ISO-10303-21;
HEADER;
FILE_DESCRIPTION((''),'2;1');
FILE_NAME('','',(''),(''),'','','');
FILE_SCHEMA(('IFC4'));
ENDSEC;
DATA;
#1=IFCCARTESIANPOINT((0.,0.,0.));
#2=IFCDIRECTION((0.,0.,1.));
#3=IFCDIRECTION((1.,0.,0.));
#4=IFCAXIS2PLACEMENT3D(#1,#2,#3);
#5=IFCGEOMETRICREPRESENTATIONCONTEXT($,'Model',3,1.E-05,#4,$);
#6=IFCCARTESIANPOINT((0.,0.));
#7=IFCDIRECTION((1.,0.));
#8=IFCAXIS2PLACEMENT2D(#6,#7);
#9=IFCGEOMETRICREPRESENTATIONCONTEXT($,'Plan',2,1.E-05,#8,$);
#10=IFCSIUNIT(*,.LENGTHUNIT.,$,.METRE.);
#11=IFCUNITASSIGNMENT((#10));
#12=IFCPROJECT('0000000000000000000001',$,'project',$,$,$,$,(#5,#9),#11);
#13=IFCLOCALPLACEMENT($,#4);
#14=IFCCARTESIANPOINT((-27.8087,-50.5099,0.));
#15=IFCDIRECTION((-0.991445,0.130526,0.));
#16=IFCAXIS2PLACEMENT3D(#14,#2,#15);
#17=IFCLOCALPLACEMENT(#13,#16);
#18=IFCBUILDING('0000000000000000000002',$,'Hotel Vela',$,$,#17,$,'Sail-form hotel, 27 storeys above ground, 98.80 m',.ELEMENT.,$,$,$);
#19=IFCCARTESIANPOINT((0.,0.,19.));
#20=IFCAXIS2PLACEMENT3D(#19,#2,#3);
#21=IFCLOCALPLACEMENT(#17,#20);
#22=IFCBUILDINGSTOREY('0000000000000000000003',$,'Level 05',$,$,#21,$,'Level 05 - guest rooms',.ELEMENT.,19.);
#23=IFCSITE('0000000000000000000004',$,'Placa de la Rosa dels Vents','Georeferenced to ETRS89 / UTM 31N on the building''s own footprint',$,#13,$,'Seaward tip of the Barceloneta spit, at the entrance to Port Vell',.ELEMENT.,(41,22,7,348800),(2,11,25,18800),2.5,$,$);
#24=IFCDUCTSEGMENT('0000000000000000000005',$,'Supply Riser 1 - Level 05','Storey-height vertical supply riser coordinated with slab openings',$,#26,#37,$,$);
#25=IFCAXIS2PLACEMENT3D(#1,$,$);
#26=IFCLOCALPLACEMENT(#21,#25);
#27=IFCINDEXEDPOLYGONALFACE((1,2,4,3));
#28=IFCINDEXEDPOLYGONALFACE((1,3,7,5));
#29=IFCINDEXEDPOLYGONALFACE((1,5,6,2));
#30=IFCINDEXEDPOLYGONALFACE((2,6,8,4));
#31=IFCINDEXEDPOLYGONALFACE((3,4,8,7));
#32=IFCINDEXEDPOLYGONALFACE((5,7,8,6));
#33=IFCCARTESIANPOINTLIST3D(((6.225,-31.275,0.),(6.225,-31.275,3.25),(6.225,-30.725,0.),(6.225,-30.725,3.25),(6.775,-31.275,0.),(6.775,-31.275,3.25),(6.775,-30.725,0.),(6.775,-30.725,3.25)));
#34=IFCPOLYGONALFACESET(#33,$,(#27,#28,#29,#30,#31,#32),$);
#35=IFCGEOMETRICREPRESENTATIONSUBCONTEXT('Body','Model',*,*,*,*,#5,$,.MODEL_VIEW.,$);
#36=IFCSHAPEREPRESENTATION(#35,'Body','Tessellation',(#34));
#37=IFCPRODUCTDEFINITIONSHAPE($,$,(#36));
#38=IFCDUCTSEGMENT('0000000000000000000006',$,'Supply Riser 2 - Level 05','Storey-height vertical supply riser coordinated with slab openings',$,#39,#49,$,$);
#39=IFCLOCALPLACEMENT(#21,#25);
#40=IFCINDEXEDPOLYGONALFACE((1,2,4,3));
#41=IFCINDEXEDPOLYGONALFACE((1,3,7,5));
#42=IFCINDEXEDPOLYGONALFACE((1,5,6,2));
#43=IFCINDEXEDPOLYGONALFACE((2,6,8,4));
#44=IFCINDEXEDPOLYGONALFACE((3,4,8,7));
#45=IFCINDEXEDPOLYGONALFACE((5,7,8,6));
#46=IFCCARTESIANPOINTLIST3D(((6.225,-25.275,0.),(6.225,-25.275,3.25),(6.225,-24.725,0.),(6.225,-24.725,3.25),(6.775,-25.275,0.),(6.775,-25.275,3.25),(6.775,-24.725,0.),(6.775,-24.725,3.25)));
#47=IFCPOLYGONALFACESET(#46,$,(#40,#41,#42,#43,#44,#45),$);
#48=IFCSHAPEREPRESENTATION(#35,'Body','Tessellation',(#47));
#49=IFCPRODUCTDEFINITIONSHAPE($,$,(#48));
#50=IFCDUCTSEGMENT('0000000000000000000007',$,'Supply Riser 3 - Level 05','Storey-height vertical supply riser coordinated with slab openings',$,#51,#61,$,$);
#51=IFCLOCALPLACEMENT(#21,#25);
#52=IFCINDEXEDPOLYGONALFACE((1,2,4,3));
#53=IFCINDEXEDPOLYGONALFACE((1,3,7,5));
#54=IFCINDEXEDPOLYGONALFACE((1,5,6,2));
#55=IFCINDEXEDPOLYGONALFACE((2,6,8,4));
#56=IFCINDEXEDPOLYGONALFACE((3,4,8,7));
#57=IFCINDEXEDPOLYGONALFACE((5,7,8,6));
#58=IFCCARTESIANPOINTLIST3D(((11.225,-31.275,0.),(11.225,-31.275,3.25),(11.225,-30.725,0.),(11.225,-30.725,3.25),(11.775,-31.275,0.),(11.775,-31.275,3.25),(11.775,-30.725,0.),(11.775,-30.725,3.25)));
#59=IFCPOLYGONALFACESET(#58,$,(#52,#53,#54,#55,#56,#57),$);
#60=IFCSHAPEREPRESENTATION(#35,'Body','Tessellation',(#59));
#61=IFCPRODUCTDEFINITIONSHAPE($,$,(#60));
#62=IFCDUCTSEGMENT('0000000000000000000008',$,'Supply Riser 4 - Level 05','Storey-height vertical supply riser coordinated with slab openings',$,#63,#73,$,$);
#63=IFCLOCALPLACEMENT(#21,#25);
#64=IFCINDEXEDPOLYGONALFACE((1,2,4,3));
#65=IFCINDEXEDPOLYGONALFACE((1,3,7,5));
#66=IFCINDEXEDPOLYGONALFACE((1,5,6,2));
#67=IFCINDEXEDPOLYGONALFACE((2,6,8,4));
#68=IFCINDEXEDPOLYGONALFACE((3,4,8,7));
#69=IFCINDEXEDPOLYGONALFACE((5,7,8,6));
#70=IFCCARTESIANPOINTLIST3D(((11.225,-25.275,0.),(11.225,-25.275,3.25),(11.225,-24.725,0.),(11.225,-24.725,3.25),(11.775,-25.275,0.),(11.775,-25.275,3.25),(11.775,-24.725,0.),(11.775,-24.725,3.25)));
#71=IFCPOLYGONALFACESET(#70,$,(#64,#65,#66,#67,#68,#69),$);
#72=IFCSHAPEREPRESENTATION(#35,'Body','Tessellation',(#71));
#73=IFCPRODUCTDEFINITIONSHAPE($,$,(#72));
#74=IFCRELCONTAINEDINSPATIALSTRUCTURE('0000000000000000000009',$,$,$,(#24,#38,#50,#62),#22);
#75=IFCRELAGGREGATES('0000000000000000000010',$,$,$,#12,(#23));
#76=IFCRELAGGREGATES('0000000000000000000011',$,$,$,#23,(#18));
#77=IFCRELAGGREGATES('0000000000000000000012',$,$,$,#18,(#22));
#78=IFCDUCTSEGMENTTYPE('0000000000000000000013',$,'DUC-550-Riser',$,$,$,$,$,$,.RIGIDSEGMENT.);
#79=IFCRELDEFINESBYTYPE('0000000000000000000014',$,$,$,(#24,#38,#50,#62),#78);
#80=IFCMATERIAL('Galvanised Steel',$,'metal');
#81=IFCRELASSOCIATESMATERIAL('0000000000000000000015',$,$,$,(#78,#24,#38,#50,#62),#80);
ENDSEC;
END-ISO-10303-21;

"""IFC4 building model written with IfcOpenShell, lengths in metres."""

from ifc_helpers import new_model, si_unit, frame, origin_with_axes, origin_2d_with_axis, place, context, subcontext, project, spatial, line, indexed_curve, outline, extrude, material, type_object, element, save


model = new_model("IFC4")

# Units and contexts
model_context = context("Model", 3, precision=1e-05, world=origin_with_axes())
plan_context = context("Plan", 2, precision=1e-05, world=origin_2d_with_axis())
body_context = subcontext(model_context, "Body", "Model", "MODEL_VIEW")
ifc_project = project(units=[si_unit("LENGTHUNIT", "METRE")], contexts=[model_context, plan_context])

# Site, building, storey
site_placement = place(None, origin_with_axes())
site = spatial("IfcSite", under=ifc_project, at=site_placement, Name="Placa de la Rosa dels Vents", Description="Georeferenced to ETRS89 / UTM 31N on the building's own footprint", LongName="Seaward tip of the Barceloneta spit, at the entrance to Port Vell", CompositionType="ELEMENT", RefLatitude=(41, 22, 7, 348800), RefLongitude=(2, 11, 25, 18800), RefElevation=2.5)
building_placement = place(site_placement, frame((-27.8087, -50.5099, 0.0), z_axis=(0.0, 0.0, 1.0), x_axis=(-0.991445, 0.130526, 0.0)))
building = spatial("IfcBuilding", under=site, at=building_placement, Name="Hotel Vela", LongName="Sail-form hotel, 27 storeys above ground, 98.80 m", CompositionType="ELEMENT")
storey_placement = place(building_placement, frame((0.0, 0.0, 19.0), z_axis=(0.0, 0.0, 1.0), x_axis=(1.0, 0.0, 0.0)))
storey = spatial("IfcBuildingStorey", under=building, at=storey_placement, Name="Level 05", LongName="Level 05 - guest rooms", CompositionType="ELEMENT", Elevation=19.0)

# Duct segments
ifc_material = material(Name="Galvanised Steel", Category="metal")
duct_segment_type = type_object("IfcDuctSegmentType", Name="DUC-550-Riser", PredefinedType="RIGIDSEGMENT", material=ifc_material)
for number, where, z_axis, x_axis, name in (
    (1, (6.225, -31.275, 0.0), (0.0, 0.0, 1.0), (1.0, 0.0, 0.0), "Supply Riser 1 - Level 05"),
    (2, (6.225, -25.275, 0.0), (0.0, 0.0, 1.0), (1.0, 0.0, 0.0), "Supply Riser 2 - Level 05"),
    (3, (11.225, -31.275, 0.0), (0.0, 0.0, 1.0), (1.0, 0.0, 0.0), "Supply Riser 3 - Level 05"),
    (4, (11.225, -25.275, 0.0), (0.0, 0.0, 1.0), (1.0, 0.0, 0.0), "Supply Riser 4 - Level 05"),
):
    element("IfcDuctSegment", number, at=place(storey_placement, frame(where, z_axis=z_axis, x_axis=x_axis)), inside=storey, type_object=duct_segment_type, material=ifc_material, Name=name, Description="Storey-height vertical supply riser coordinated with slab openings", context=body_context, shape_type="SweptSolid", body=[
        extrude(outline(indexed_curve([(0.0, 0.0), (0.55, 0.0), (0.55, 0.55), (0.0, 0.55)], segments=[line(1, 2, 3, 4, 1)])), origin_with_axes(), (0.0, 0.0, 1.0), 3.25),
    ])

save(model, "model.ifc")
